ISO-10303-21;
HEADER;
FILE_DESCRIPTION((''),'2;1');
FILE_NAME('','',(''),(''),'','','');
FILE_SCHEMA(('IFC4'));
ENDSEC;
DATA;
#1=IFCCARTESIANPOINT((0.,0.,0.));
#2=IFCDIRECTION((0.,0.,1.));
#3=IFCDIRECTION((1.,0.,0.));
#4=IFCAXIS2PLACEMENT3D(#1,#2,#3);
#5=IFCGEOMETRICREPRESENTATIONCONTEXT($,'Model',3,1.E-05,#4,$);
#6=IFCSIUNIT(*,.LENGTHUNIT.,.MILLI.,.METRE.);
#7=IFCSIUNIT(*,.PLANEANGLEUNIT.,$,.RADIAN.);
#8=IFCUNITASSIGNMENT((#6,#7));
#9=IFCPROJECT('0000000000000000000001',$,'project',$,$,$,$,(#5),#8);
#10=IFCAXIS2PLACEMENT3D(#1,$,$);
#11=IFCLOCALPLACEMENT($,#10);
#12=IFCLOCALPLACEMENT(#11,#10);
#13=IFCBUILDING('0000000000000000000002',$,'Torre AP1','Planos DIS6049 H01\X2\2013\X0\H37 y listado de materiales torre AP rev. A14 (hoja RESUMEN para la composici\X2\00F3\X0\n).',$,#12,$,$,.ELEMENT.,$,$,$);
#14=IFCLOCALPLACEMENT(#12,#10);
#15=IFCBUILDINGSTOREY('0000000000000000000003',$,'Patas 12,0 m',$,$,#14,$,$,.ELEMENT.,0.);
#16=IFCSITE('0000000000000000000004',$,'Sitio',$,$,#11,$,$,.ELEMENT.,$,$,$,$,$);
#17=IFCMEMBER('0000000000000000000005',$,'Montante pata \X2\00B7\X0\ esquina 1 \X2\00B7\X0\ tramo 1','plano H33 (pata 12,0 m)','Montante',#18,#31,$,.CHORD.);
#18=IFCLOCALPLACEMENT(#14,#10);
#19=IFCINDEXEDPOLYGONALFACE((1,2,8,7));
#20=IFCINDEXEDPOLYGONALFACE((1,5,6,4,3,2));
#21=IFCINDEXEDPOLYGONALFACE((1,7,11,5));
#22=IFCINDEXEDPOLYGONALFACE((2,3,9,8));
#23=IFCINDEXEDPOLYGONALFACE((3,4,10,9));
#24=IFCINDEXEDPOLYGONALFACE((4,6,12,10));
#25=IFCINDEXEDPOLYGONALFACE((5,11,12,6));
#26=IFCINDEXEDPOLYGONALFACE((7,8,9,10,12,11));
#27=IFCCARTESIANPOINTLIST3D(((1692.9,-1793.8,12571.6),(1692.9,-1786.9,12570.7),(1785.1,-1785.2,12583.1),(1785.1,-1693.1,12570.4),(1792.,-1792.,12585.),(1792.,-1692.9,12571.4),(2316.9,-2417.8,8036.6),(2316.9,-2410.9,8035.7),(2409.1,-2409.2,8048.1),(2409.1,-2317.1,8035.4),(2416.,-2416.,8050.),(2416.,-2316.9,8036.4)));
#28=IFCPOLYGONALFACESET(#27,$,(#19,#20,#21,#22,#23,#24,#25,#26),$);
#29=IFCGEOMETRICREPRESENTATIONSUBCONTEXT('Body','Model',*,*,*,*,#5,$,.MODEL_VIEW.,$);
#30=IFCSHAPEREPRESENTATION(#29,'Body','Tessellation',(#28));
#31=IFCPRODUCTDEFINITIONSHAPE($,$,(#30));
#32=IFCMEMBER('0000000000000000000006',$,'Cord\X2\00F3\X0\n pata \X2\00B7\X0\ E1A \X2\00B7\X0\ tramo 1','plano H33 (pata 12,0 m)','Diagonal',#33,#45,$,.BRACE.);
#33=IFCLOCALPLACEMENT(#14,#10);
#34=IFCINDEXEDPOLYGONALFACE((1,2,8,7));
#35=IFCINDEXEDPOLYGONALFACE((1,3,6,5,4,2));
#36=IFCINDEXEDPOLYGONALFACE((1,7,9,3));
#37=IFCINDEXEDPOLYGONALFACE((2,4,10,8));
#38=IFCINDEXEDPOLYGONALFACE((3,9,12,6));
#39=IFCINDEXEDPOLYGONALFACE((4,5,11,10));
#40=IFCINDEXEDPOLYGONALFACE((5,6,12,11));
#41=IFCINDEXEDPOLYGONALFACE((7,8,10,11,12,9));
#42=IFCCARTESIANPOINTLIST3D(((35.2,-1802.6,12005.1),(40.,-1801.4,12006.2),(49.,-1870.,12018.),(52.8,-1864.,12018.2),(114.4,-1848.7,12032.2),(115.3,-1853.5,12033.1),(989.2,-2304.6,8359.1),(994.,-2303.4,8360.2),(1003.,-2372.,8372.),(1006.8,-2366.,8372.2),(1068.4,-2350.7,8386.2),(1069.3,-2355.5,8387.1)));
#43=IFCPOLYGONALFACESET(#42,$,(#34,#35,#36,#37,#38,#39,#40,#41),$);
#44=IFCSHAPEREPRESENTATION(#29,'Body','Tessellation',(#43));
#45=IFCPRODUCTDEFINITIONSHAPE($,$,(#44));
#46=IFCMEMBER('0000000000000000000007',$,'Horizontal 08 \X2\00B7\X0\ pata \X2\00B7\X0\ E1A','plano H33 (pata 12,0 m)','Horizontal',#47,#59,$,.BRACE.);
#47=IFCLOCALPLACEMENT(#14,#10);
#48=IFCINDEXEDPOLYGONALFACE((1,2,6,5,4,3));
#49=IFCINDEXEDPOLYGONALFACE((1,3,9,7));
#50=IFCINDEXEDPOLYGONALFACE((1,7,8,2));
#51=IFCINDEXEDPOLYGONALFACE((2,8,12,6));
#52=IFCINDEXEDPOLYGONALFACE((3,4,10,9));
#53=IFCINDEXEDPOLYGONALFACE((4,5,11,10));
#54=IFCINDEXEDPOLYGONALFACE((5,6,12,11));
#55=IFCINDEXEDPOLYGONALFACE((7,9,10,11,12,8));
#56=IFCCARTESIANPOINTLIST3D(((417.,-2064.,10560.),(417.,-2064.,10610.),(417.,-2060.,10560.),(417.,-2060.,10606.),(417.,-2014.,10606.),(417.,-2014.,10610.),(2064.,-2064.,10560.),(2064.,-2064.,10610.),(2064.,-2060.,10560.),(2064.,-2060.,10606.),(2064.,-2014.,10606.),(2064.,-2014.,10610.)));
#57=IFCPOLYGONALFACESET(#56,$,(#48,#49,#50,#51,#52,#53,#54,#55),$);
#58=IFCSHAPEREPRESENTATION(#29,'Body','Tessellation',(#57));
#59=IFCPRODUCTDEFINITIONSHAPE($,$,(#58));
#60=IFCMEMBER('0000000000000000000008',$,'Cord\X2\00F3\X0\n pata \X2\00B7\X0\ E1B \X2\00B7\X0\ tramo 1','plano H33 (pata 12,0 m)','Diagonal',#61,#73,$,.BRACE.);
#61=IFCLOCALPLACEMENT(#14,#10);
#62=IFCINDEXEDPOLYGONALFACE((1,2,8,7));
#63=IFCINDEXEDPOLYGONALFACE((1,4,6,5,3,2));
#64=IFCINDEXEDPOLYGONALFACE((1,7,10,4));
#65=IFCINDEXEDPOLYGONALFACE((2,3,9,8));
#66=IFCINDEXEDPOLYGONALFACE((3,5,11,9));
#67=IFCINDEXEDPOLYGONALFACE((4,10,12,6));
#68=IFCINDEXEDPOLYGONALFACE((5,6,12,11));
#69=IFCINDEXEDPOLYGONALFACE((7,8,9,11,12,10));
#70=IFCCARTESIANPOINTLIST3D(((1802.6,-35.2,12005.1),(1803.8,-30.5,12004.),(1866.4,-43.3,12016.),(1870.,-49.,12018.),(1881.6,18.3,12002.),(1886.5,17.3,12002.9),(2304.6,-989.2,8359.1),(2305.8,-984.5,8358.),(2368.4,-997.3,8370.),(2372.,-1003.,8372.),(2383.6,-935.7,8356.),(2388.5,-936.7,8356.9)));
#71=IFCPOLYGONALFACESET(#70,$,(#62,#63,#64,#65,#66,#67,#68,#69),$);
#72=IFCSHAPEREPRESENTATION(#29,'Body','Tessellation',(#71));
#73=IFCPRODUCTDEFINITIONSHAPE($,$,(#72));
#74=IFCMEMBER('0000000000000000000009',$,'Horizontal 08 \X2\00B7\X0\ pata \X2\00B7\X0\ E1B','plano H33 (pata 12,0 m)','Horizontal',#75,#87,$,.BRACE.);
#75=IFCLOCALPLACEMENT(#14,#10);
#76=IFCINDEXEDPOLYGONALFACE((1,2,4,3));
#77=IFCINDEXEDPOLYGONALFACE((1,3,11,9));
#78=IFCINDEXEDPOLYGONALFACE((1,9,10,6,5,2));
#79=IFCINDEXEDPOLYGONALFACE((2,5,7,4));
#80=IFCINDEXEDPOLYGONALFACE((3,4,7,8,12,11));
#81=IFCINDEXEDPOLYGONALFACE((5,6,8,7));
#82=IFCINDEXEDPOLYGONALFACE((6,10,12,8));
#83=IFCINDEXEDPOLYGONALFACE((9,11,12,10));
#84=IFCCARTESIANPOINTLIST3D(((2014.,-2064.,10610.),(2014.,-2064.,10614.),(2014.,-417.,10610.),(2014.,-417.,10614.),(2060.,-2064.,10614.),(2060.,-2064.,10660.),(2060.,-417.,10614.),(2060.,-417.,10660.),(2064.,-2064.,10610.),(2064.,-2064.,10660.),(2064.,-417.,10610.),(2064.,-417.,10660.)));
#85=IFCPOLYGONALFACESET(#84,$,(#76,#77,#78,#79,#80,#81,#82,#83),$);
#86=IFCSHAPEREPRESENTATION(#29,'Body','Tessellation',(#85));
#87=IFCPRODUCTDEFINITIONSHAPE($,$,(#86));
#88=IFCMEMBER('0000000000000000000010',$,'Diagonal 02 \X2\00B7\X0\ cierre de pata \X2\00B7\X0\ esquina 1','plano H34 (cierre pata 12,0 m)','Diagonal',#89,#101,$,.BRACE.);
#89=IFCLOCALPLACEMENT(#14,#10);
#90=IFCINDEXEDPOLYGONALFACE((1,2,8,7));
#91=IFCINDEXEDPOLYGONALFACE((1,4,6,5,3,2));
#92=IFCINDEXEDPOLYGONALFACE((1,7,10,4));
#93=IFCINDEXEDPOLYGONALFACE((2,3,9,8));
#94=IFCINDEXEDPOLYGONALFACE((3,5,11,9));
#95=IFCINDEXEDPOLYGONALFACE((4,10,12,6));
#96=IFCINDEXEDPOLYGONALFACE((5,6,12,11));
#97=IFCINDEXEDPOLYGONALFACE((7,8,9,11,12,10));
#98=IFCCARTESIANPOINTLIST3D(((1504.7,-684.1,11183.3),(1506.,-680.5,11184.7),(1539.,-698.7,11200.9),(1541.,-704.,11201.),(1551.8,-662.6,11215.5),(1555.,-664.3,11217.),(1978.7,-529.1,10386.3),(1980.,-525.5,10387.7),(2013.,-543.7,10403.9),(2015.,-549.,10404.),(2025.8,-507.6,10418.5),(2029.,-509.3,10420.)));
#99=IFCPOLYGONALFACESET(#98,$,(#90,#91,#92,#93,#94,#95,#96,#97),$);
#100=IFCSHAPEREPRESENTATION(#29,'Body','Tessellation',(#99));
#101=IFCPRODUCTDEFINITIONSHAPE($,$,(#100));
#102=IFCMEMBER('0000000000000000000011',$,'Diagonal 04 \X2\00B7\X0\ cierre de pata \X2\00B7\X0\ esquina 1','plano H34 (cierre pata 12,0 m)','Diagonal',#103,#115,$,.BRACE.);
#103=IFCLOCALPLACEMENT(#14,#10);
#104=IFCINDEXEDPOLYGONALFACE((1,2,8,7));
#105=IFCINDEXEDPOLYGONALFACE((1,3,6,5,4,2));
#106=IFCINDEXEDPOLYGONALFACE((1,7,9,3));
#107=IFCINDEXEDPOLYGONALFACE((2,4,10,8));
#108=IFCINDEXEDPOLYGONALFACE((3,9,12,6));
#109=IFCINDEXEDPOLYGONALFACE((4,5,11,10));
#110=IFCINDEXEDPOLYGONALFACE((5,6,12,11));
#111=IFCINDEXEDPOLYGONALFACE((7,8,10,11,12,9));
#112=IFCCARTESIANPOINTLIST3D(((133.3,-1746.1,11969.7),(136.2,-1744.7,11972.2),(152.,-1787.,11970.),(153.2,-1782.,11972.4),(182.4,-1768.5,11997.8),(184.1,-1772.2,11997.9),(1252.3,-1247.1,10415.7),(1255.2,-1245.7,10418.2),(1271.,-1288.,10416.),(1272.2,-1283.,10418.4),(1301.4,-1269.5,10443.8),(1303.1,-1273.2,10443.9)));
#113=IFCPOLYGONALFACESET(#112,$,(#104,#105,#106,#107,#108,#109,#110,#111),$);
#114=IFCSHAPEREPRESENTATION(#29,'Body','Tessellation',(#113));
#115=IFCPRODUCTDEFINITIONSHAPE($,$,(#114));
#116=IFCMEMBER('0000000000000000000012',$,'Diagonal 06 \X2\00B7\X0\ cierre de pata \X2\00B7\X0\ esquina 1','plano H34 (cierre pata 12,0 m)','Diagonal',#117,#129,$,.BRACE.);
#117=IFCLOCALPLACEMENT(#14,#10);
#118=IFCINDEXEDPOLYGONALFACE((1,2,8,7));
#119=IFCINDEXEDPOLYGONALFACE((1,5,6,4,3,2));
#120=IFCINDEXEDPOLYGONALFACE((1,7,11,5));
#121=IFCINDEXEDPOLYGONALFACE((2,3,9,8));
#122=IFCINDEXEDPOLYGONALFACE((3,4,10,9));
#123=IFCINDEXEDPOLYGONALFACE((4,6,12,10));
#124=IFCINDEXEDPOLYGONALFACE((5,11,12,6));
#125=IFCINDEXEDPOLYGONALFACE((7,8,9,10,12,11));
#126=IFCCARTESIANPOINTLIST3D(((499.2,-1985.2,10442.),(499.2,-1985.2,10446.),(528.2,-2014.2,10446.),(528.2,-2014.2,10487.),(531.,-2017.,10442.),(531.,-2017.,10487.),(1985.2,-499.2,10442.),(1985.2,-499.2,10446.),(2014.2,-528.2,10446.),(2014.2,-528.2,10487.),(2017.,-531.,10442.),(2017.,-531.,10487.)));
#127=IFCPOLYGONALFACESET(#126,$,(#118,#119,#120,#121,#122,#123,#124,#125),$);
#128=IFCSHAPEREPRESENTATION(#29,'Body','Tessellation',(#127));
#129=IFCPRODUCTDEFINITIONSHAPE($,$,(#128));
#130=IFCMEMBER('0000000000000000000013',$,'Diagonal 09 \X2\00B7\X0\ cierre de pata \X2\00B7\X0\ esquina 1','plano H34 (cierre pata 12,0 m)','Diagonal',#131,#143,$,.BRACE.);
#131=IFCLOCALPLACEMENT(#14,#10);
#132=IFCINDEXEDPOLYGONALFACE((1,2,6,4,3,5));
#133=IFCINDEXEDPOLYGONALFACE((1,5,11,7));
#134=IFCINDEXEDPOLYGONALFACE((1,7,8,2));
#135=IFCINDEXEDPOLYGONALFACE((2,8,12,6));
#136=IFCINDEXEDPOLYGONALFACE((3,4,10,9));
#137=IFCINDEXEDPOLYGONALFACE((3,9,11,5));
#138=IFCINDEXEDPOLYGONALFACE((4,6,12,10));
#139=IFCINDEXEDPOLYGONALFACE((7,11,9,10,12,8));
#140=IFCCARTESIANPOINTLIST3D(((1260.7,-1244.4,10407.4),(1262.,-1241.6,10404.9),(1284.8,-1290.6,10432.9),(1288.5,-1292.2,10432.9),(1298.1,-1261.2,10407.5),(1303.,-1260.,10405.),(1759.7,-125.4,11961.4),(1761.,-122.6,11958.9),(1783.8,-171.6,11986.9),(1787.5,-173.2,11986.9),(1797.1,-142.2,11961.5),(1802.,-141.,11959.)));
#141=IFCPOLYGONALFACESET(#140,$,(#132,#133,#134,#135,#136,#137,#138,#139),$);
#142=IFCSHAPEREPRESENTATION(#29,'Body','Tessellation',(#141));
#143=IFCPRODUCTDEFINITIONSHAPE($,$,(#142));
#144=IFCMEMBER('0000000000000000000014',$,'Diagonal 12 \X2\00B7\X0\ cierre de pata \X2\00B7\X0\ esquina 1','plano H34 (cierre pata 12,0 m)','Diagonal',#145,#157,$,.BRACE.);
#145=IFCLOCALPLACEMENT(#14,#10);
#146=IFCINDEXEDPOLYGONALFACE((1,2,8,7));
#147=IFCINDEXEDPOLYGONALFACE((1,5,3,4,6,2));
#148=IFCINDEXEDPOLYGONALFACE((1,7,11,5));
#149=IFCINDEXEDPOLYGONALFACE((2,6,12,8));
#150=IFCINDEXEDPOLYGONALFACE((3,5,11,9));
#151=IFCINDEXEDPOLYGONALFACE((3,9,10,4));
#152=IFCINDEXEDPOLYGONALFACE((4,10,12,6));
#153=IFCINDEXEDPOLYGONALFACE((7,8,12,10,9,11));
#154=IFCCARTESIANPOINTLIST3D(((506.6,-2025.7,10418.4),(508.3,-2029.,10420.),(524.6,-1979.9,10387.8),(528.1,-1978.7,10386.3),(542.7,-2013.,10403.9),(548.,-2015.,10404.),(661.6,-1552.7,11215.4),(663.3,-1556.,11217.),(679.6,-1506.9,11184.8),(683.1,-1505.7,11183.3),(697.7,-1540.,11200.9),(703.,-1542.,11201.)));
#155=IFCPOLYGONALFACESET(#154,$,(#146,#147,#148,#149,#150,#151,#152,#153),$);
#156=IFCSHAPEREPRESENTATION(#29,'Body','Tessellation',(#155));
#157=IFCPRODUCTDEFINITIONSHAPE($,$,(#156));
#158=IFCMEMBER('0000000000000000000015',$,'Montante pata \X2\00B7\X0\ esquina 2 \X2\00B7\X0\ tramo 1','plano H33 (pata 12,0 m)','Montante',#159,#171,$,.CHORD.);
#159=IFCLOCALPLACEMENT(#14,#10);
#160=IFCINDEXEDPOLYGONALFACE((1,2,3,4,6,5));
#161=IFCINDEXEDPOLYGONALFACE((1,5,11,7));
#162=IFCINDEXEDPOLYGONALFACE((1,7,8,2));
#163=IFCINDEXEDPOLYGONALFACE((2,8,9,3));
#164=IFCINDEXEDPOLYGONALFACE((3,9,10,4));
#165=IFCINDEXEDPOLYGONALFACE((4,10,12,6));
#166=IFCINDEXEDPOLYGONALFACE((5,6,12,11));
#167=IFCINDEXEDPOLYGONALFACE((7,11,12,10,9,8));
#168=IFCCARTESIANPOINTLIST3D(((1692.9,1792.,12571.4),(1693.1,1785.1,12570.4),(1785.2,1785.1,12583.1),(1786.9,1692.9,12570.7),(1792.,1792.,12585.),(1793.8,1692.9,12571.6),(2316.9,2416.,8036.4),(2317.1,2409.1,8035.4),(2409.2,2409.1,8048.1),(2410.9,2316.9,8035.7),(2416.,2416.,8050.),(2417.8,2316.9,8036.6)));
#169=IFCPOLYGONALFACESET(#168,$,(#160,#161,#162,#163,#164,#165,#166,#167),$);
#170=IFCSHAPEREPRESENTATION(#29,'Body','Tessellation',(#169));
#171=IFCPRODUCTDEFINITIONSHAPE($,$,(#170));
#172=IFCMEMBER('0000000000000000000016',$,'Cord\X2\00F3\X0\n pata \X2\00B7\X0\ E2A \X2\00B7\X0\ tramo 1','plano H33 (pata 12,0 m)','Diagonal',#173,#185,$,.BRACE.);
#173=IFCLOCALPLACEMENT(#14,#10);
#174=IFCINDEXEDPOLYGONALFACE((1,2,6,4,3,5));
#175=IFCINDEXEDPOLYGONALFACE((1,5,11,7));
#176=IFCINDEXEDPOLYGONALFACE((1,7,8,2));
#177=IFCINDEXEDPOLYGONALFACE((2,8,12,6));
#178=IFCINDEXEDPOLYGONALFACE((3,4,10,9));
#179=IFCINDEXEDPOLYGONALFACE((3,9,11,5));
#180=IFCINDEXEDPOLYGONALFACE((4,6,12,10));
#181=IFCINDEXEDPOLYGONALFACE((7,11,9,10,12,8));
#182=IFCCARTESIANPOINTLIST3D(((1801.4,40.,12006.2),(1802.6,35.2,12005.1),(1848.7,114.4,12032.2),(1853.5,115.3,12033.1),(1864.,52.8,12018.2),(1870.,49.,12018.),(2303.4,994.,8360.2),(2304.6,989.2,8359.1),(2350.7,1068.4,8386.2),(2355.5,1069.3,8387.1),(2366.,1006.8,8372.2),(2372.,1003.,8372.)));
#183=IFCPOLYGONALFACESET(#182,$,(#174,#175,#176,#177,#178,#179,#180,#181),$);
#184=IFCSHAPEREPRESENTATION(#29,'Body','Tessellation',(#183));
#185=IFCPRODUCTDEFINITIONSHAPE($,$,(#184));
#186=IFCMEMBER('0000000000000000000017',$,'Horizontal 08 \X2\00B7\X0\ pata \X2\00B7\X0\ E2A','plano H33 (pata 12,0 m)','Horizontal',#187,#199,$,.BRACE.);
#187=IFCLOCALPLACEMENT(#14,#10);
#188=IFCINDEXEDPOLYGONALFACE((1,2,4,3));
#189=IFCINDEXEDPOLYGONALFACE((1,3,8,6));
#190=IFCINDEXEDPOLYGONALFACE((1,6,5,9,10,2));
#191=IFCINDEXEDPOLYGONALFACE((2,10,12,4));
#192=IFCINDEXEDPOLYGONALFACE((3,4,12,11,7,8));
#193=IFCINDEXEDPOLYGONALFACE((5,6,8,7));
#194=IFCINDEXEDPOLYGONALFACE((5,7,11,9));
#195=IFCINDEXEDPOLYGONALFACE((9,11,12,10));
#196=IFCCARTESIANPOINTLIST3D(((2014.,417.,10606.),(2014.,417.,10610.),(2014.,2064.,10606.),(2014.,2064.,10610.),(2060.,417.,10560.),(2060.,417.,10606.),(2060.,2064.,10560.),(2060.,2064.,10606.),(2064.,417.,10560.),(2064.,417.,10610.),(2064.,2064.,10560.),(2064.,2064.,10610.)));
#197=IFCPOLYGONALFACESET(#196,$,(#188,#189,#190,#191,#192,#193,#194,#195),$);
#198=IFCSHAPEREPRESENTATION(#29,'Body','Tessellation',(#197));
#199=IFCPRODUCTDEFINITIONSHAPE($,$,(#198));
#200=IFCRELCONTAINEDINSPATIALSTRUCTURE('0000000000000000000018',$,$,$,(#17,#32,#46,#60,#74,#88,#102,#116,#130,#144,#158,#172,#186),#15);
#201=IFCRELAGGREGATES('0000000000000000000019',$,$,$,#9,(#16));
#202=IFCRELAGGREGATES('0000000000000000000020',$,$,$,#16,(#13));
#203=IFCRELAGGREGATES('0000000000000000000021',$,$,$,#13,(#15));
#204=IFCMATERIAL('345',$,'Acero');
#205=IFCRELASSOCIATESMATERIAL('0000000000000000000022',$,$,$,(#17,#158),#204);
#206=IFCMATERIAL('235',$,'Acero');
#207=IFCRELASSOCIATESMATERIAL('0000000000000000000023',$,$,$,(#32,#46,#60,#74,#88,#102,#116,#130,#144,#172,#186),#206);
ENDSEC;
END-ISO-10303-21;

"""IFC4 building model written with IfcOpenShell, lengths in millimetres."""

from ifc_helpers import new_model, si_unit, frame, frame_2d, origin, origin_with_axes, place, context, subcontext, project, spatial, l_section, extrude, material, element, save


model = new_model("IFC4")

# Units and contexts
model_context = context("Model", 3, precision=1e-05, world=origin_with_axes())
body_context = subcontext(model_context, "Body", "Model", "MODEL_VIEW")
ifc_project = project(units=[si_unit("LENGTHUNIT", "METRE", prefix="MILLI"), si_unit("PLANEANGLEUNIT", "RADIAN")], contexts=[model_context])

# Site, building, storey
site_placement = place(None, origin())
site = spatial("IfcSite", under=ifc_project, at=site_placement, Name="Sitio", CompositionType="ELEMENT")
building_placement = place(site_placement, origin())
building = spatial("IfcBuilding", under=site, at=building_placement, Name="Torre AP1", Description="Planos DIS6049 H01–H37 y listado de materiales torre AP rev. A14 (hoja RESUMEN para la composición).", CompositionType="ELEMENT")
storey_placement = place(building_placement, origin())
storey = spatial("IfcBuildingStorey", under=building, at=storey_placement, Name="Patas 12,0 m", CompositionType="ELEMENT", Elevation=0.0)

# Members
ifc_material_1 = material(Name="345", Category="Acero")
member_1_placement = place(storey_placement, frame((1792.0, -1792.0, 12585.0), z_axis=(0.135063, -0.135063, -0.981588), x_axis=(-0.990837, -0.018411, -0.133802)))
element("IfcMember", 1, at=member_1_placement, inside=storey, material=ifc_material_1, Name="Montante pata · esquina 1 · tramo 1", Description="plano H33 (pata 12,0 m)", ObjectType="Montante", PredefinedType="CHORD", context=body_context, shape_type="SweptSolid", body=[
    extrude(l_section(Depth=100.0, Width=100.0, Thickness=7.0, at=frame_2d((50.0, 50.0))), None, (0.0, 0.0, 1.0), 4620.1),
])
ifc_material_2 = material(Name="235", Category="Acero")
member_2_placement = place(storey_placement, frame((49.0, -1870.0, 12018.0), z_axis=(0.250919, -0.132035, -0.958961), x_axis=(-0.196926, 0.962976, -0.184114)))
element("IfcMember", 2, at=member_2_placement, inside=storey, material=ifc_material_2, Name="Cordón pata · E1A · tramo 1", Description="plano H33 (pata 12,0 m)", ObjectType="Diagonal", PredefinedType="BRACE", context=body_context, shape_type="SweptSolid", body=[
    extrude(l_section(Depth=70.0, Width=70.0, Thickness=5.0, at=frame_2d((35.0, 35.0))), None, (0.0, 0.0, 1.0), 3802.0),
])
member_3_placement = place(storey_placement, frame((2064.0, -2064.0, 10610.0), z_axis=(-1.0, 0.0, 0.0), x_axis=(0.0, 1.0, 0.0)))
element("IfcMember", 3, at=member_3_placement, inside=storey, material=ifc_material_2, Name="Horizontal 08 · pata · E1A", Description="plano H33 (pata 12,0 m)", ObjectType="Horizontal", PredefinedType="BRACE", context=body_context, shape_type="SweptSolid", body=[
    extrude(l_section(Depth=50.0, Width=50.0, Thickness=4.0, at=frame_2d((25.0, 25.0))), None, (0.0, 0.0, 1.0), 1647.0),
])
member_4_placement = place(storey_placement, frame((1870.0, -49.0, 12018.0), z_axis=(0.132035, -0.250919, -0.958961), x_axis=(-0.962976, 0.196926, -0.184114)))
element("IfcMember", 4, at=member_4_placement, inside=storey, material=ifc_material_2, Name="Cordón pata · E1B · tramo 1", Description="plano H33 (pata 12,0 m)", ObjectType="Diagonal", PredefinedType="BRACE", context=body_context, shape_type="SweptSolid", body=[
    extrude(l_section(Depth=70.0, Width=70.0, Thickness=5.0, at=frame_2d((35.0, 35.0))), None, (0.0, 0.0, 1.0), 3802.0),
])
member_5_placement = place(storey_placement, frame((2064.0, -2064.0, 10610.0), z_axis=(0.0, 1.0, 0.0), x_axis=(-1.0, 0.0, 0.0)))
element("IfcMember", 5, at=member_5_placement, inside=storey, material=ifc_material_2, Name="Horizontal 08 · pata · E1B", Description="plano H33 (pata 12,0 m)", ObjectType="Horizontal", PredefinedType="BRACE", context=body_context, shape_type="SweptSolid", body=[
    extrude(l_section(Depth=50.0, Width=50.0, Thickness=4.0, at=frame_2d((25.0, 25.0))), None, (0.0, 0.0, 1.0), 1647.0),
])
member_6_placement = place(storey_placement, frame((1541.0, -704.0, 11201.0), z_axis=(0.504167, 0.164865, -0.847724), x_axis=(-0.805838, 0.442792, -0.393142)))
element("IfcMember", 6, at=member_6_placement, inside=storey, material=ifc_material_2, Name="Diagonal 02 · cierre de pata · esquina 1", Description="plano H34 (cierre pata 12,0 m)", ObjectType="Diagonal", PredefinedType="BRACE", context=body_context, shape_type="SweptSolid", body=[
    extrude(l_section(Depth=45.0, Width=45.0, Thickness=4.0, at=frame_2d((22.5, 22.5))), None, (0.0, 0.0, 1.0), 940.2),
])
member_7_placement = place(storey_placement, frame((152.0, -1787.0, 11970.0), z_axis=(0.565463, 0.252159, -0.785281), x_axis=(-0.415107, 0.909747, -0.006783)))
element("IfcMember", 7, at=member_7_placement, inside=storey, material=ifc_material_2, Name="Diagonal 04 · cierre de pata · esquina 1", Description="plano H34 (cierre pata 12,0 m)", ObjectType="Diagonal", PredefinedType="BRACE", context=body_context, shape_type="SweptSolid", body=[
    extrude(l_section(Depth=45.0, Width=45.0, Thickness=4.0, at=frame_2d((22.5, 22.5))), None, (0.0, 0.0, 1.0), 1978.9),
])
member_8_placement = place(storey_placement, frame((531.0, -2017.0, 10442.0), z_axis=(0.707107, 0.707107, 0.0), x_axis=(-0.707107, 0.707107, 0.0)))
element("IfcMember", 8, at=member_8_placement, inside=storey, material=ifc_material_2, Name="Diagonal 06 · cierre de pata · esquina 1", Description="plano H34 (cierre pata 12,0 m)", ObjectType="Diagonal", PredefinedType="BRACE", context=body_context, shape_type="SweptSolid", body=[
    extrude(l_section(Depth=45.0, Width=45.0, Thickness=4.0, at=frame_2d((22.5, 22.5))), None, (0.0, 0.0, 1.0), 2101.5),
])
member_9_placement = place(storey_placement, frame((1303.0, -1260.0, 10405.0), z_axis=(0.252159, 0.565463, 0.785281), x_axis=(-0.912198, 0.409744, -0.002135)))
element("IfcMember", 9, at=member_9_placement, inside=storey, material=ifc_material_2, Name="Diagonal 09 · cierre de pata · esquina 1", Description="plano H34 (cierre pata 12,0 m)", ObjectType="Diagonal", PredefinedType="BRACE", context=body_context, shape_type="SweptSolid", body=[
    extrude(l_section(Depth=45.0, Width=45.0, Thickness=4.0, at=frame_2d((22.5, 22.5))), None, (0.0, 0.0, 1.0), 1978.9),
])
member_10_placement = place(storey_placement, frame((548.0, -2015.0, 10404.0), z_axis=(0.164953, 0.503373, 0.848178), x_axis=(-0.441981, 0.806505, -0.392685)))
element("IfcMember", 10, at=member_10_placement, inside=storey, material=ifc_material_2, Name="Diagonal 12 · cierre de pata · esquina 1", Description="plano H34 (cierre pata 12,0 m)", ObjectType="Diagonal", PredefinedType="BRACE", context=body_context, shape_type="SweptSolid", body=[
    extrude(l_section(Depth=45.0, Width=45.0, Thickness=4.0, at=frame_2d((22.5, 22.5))), None, (0.0, 0.0, 1.0), 939.7),
])
member_11_placement = place(storey_placement, frame((1792.0, 1792.0, 12585.0), z_axis=(0.135063, 0.135063, -0.981588), x_axis=(0.018411, -0.990837, -0.133802)))
element("IfcMember", 11, at=member_11_placement, inside=storey, material=ifc_material_1, Name="Montante pata · esquina 2 · tramo 1", Description="plano H33 (pata 12,0 m)", ObjectType="Montante", PredefinedType="CHORD", context=body_context, shape_type="SweptSolid", body=[
    extrude(l_section(Depth=100.0, Width=100.0, Thickness=7.0, at=frame_2d((50.0, 50.0))), None, (0.0, 0.0, 1.0), 4620.1),
])
member_12_placement = place(storey_placement, frame((1870.0, 49.0, 12018.0), z_axis=(0.132035, 0.250919, -0.958961), x_axis=(-0.962976, -0.196926, -0.184114)))
element("IfcMember", 12, at=member_12_placement, inside=storey, material=ifc_material_2, Name="Cordón pata · E2A · tramo 1", Description="plano H33 (pata 12,0 m)", ObjectType="Diagonal", PredefinedType="BRACE", context=body_context, shape_type="SweptSolid", body=[
    extrude(l_section(Depth=70.0, Width=70.0, Thickness=5.0, at=frame_2d((35.0, 35.0))), None, (0.0, 0.0, 1.0), 3802.0),
])
member_13_placement = place(storey_placement, frame((2064.0, 2064.0, 10610.0), z_axis=(0.0, -1.0, 0.0), x_axis=(-1.0, 0.0, 0.0)))
element("IfcMember", 13, at=member_13_placement, inside=storey, material=ifc_material_2, Name="Horizontal 08 · pata · E2A", Description="plano H33 (pata 12,0 m)", ObjectType="Horizontal", PredefinedType="BRACE", context=body_context, shape_type="SweptSolid", body=[
    extrude(l_section(Depth=50.0, Width=50.0, Thickness=4.0, at=frame_2d((25.0, 25.0))), None, (0.0, 0.0, 1.0), 1647.0),
])

save(model, "model.ifc")
